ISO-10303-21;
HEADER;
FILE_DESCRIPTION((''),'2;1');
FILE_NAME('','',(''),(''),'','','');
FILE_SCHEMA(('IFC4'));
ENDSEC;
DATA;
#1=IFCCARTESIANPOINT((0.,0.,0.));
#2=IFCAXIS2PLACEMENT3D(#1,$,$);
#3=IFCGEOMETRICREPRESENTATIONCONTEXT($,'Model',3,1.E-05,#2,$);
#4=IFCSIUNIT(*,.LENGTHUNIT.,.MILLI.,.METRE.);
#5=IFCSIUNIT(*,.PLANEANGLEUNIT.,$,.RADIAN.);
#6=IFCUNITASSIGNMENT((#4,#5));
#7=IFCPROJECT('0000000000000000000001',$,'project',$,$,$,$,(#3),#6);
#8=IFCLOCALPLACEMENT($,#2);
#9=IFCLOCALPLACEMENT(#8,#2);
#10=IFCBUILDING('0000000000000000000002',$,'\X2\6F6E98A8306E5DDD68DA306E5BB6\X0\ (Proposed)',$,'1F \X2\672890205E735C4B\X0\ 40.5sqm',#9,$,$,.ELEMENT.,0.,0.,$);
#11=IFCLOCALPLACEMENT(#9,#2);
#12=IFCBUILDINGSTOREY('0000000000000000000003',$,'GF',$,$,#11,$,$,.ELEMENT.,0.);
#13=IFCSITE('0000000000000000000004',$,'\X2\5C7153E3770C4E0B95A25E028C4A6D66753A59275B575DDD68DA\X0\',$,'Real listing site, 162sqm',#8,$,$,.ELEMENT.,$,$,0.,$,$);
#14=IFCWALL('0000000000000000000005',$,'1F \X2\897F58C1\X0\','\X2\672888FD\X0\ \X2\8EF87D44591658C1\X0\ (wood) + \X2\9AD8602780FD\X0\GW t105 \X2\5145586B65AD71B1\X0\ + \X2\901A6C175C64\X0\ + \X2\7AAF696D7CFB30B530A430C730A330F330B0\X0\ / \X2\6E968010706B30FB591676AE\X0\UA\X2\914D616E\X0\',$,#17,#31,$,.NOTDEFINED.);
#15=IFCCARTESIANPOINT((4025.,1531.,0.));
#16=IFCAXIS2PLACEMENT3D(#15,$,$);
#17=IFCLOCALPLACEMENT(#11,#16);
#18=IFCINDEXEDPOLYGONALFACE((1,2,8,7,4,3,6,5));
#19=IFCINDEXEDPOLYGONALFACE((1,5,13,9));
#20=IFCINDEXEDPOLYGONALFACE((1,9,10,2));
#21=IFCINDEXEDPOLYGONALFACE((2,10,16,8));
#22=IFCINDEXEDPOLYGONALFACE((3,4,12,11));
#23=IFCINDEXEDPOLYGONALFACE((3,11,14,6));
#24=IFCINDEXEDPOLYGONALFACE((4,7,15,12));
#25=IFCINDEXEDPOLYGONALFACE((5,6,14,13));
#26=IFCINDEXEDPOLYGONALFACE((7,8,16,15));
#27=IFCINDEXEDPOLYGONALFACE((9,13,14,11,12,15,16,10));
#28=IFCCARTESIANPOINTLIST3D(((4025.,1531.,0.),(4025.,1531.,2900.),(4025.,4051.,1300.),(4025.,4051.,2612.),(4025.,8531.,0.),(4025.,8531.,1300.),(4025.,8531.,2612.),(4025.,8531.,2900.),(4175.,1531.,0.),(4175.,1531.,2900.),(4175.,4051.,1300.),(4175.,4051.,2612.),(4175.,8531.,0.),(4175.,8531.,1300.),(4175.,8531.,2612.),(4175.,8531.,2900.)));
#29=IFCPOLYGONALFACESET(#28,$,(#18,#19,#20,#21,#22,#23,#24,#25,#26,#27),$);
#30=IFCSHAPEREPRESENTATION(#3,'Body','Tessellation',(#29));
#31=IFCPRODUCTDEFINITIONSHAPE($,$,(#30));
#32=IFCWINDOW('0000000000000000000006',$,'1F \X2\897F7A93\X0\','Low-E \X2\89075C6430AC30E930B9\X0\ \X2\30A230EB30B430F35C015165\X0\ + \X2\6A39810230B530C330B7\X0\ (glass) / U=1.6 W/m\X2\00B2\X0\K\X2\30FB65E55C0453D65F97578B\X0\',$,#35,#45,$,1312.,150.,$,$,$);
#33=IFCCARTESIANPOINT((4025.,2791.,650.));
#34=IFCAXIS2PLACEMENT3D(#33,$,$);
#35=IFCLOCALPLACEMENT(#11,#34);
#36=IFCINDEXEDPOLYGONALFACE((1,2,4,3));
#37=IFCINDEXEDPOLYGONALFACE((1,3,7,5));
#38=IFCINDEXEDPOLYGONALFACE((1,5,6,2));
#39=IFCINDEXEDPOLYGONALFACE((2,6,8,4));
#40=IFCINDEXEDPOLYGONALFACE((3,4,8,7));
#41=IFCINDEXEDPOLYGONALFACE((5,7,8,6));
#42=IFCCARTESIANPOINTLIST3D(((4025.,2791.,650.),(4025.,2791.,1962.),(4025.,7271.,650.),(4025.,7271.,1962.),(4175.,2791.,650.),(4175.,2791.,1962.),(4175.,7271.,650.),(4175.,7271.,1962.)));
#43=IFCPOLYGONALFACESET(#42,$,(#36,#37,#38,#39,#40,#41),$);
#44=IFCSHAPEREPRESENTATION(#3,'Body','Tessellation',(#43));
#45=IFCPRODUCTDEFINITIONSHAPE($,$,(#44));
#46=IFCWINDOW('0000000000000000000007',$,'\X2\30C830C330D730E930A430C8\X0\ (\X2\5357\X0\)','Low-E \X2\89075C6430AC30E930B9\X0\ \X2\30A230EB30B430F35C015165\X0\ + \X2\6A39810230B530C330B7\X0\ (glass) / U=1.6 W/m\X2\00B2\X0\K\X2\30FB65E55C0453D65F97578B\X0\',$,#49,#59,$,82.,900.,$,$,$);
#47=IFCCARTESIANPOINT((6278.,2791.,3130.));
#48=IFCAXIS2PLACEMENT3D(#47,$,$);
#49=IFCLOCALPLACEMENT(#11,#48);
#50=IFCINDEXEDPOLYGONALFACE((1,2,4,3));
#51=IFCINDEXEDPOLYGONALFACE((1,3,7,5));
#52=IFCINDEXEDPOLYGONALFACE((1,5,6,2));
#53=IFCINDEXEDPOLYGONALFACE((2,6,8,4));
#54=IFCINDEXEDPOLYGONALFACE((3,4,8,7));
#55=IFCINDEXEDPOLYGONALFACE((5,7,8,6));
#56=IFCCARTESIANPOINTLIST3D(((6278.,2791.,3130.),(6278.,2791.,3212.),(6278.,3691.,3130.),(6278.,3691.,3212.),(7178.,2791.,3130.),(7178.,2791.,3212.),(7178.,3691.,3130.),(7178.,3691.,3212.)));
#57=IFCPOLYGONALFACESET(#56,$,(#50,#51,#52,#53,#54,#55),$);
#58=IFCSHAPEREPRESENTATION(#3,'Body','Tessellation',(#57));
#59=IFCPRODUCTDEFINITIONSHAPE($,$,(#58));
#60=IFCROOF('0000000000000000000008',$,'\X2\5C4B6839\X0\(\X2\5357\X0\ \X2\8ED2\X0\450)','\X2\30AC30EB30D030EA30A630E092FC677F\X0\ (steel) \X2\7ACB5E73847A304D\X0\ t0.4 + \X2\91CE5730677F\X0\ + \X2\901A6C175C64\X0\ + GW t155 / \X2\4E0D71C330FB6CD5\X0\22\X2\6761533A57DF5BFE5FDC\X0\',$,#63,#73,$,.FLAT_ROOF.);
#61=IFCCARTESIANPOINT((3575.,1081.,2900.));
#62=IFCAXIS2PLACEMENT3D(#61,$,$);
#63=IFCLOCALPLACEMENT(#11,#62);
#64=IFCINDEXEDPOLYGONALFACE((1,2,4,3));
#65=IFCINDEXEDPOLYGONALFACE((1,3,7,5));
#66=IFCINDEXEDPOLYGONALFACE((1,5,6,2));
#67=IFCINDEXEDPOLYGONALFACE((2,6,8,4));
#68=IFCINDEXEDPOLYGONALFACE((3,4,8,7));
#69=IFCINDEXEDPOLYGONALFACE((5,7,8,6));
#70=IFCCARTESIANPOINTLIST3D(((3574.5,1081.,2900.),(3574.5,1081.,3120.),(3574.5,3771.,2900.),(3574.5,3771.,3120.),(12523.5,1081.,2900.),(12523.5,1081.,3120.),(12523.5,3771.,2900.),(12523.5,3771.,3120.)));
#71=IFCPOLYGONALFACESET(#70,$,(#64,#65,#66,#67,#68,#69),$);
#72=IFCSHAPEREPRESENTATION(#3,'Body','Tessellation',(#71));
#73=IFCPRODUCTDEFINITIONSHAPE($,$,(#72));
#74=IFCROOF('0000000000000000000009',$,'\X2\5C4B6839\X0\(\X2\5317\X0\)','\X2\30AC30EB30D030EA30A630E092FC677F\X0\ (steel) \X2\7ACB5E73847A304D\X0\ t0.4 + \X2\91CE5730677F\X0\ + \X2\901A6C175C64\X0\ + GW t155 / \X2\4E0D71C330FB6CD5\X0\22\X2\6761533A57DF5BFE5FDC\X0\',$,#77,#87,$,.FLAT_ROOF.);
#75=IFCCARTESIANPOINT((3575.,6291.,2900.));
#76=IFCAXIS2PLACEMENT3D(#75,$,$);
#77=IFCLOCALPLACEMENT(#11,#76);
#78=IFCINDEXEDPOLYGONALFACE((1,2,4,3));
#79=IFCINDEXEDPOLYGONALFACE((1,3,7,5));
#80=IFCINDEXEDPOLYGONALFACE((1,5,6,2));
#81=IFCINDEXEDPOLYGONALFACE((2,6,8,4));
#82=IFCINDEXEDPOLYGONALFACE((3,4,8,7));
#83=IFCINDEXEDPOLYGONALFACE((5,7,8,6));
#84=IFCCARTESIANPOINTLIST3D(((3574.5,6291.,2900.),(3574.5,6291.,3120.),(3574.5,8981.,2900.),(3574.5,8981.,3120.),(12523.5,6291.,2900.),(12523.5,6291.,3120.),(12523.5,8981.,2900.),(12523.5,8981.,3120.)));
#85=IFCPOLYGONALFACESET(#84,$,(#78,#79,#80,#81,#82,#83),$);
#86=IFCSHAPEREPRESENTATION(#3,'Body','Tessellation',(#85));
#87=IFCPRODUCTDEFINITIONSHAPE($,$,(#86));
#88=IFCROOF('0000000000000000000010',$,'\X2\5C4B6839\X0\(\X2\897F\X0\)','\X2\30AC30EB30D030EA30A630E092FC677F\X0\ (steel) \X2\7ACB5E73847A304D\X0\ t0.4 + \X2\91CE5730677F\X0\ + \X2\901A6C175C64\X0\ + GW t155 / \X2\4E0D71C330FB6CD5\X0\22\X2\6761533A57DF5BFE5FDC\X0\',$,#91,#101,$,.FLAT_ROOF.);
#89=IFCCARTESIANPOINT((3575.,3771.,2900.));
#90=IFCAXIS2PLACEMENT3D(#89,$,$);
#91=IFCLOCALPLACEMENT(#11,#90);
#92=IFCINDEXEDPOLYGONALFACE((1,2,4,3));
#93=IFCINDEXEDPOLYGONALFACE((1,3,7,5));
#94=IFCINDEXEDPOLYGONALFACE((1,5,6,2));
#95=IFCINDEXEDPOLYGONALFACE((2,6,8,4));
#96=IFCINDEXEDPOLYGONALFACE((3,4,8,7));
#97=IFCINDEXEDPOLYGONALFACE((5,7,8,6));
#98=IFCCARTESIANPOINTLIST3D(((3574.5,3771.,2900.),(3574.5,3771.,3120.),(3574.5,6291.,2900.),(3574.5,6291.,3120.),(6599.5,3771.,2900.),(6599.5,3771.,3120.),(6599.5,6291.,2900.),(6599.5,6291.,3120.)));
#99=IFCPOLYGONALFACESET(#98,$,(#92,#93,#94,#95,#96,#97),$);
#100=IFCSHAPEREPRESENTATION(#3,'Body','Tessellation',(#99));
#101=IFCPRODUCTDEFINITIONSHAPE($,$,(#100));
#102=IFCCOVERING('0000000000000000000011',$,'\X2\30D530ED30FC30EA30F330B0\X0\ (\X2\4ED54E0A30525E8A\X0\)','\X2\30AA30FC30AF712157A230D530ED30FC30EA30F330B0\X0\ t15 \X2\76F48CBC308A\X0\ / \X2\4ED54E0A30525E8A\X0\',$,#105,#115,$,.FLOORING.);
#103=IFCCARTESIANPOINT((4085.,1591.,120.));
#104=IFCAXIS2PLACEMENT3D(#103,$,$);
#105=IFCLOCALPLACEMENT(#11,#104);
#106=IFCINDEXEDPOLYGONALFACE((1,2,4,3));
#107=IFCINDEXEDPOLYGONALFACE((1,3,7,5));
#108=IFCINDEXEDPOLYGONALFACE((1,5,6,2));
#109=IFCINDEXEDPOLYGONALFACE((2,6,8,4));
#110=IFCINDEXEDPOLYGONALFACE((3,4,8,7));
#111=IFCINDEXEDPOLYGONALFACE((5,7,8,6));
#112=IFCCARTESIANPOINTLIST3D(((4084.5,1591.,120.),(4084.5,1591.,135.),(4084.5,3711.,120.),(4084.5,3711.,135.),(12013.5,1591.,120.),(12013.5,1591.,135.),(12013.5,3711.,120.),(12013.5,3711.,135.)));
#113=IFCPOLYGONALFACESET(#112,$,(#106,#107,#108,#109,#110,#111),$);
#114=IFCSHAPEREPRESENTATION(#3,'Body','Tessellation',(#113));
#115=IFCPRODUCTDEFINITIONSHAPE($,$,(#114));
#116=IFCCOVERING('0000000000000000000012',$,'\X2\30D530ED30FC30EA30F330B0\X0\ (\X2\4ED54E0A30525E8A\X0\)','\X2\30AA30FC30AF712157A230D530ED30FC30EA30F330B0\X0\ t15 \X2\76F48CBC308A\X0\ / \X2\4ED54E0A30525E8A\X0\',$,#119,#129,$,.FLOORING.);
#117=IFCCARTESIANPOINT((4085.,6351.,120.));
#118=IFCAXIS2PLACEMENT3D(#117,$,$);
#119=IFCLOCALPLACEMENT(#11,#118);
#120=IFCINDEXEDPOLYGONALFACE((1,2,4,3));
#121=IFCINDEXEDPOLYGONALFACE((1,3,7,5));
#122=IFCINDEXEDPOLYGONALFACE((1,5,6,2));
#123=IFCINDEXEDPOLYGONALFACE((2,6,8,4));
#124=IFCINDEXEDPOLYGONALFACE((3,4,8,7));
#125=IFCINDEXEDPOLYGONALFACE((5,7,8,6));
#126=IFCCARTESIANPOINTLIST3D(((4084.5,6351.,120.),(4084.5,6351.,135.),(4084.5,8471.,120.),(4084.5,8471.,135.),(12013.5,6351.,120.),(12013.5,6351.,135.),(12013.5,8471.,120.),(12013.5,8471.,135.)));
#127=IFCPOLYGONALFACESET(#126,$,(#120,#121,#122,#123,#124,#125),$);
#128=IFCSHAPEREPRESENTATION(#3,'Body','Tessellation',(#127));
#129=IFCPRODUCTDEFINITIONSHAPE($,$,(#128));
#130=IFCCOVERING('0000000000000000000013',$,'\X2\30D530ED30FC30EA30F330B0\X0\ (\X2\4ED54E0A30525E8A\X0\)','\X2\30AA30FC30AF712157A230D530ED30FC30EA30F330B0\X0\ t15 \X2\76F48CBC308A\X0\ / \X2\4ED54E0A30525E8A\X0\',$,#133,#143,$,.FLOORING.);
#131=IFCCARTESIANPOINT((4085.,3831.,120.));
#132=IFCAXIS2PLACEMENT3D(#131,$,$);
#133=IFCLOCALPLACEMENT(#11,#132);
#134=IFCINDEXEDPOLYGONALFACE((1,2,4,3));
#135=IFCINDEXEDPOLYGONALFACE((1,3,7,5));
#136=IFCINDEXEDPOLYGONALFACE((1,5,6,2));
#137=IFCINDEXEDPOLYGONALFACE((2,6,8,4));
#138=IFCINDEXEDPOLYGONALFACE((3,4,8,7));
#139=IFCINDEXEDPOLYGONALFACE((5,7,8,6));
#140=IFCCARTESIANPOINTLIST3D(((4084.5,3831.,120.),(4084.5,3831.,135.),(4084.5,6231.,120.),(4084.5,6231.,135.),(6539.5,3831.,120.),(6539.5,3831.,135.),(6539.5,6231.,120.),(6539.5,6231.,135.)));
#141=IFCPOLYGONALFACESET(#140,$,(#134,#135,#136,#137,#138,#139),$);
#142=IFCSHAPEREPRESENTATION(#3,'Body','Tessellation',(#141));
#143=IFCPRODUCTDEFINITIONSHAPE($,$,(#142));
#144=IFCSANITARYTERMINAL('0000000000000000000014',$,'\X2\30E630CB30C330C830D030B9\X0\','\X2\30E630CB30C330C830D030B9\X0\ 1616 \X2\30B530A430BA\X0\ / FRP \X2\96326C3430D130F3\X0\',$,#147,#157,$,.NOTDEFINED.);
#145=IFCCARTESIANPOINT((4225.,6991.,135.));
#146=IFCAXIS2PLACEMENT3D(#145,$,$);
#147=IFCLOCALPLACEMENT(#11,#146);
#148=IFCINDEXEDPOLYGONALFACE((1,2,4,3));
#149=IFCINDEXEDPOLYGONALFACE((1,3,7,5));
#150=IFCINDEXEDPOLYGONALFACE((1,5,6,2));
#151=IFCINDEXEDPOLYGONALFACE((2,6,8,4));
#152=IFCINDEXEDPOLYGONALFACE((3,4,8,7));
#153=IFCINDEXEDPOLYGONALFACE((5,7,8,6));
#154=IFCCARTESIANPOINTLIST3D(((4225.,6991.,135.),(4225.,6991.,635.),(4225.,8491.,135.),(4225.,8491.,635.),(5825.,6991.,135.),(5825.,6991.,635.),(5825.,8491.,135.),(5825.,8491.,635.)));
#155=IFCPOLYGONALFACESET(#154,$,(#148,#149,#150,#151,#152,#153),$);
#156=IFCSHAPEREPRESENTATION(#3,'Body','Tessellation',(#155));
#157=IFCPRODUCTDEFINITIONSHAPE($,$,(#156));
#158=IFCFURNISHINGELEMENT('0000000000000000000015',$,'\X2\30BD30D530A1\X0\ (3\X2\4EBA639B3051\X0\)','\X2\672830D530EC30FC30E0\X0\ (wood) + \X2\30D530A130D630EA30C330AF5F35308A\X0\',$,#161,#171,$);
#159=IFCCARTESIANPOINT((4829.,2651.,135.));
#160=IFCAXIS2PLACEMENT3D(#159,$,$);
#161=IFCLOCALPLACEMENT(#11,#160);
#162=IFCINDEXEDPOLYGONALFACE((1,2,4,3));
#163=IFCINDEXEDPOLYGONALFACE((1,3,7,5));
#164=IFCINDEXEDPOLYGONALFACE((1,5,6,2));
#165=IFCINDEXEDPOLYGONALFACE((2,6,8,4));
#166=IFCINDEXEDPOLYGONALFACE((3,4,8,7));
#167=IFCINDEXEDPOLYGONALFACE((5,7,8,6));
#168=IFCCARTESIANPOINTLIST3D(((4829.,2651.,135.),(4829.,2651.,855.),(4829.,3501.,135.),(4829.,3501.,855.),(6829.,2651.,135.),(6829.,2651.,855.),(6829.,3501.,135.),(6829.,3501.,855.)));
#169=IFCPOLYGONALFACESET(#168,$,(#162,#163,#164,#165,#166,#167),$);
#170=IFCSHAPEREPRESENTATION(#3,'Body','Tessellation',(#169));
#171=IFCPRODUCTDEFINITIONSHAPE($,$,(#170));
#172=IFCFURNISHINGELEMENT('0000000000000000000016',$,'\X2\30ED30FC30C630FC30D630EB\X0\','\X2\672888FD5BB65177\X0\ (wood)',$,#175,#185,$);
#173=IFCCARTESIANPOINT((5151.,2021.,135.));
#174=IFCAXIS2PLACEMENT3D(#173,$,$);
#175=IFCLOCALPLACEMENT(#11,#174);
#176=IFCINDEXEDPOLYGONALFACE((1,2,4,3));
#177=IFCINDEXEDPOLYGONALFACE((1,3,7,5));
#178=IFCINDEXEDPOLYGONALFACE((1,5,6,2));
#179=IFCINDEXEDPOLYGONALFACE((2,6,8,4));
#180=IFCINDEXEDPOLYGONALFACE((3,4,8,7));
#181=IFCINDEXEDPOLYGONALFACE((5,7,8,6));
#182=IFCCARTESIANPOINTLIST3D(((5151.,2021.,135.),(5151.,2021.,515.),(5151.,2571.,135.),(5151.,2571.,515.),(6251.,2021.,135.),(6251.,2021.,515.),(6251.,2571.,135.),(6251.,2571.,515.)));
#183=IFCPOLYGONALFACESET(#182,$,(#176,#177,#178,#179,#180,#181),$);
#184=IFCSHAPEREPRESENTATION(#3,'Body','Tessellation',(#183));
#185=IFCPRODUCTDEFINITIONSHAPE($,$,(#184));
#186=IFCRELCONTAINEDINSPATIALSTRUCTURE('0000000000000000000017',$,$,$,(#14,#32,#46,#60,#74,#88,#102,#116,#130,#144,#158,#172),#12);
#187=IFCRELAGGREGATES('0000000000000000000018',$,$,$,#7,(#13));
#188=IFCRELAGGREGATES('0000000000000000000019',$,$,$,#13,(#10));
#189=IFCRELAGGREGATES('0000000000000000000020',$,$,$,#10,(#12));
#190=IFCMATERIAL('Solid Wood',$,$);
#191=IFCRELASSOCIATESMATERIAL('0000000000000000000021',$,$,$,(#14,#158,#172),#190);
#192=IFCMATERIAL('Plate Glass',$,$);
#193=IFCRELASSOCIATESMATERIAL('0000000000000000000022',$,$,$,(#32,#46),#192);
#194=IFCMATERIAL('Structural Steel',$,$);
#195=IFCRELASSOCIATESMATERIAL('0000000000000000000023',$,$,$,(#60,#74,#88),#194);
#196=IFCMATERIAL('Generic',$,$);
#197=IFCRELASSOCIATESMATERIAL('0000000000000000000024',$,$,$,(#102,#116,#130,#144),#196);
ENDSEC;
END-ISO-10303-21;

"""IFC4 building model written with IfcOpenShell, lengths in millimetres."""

from ifc_helpers import new_model, si_unit, frame, frame_2d, origin, place, context, project, spatial, rectangle, extrude, material, element, fill, save


model = new_model("IFC4")

# Units and contexts
model_context = context("Model", 3, precision=1e-05, world=origin())
ifc_project = project(units=[si_unit("LENGTHUNIT", "METRE", prefix="MILLI"), si_unit("PLANEANGLEUNIT", "RADIAN")], contexts=[model_context])

# Site, building, storey
site_placement = place(None, origin())
site = spatial("IfcSite", under=ifc_project, at=site_placement, Name="山口県下関市豊浦町大字川棚", ObjectType="Real listing site, 162sqm", CompositionType="ELEMENT", RefElevation=0.0)
building_placement = place(site_placement, origin())
building = spatial("IfcBuilding", under=site, at=building_placement, Name="潮風の川棚の家 (Proposed)", ObjectType="1F 木造平屋 40.5sqm", CompositionType="ELEMENT", ElevationOfRefHeight=0.0, ElevationOfTerrain=0.0)
storey_placement = place(building_placement, origin())
storey = spatial("IfcBuildingStorey", under=building, at=storey_placement, Name="GF", CompositionType="ELEMENT", Elevation=0.0)

# Shared definitions
ifc_material_1 = material(Name="Solid Wood")

# Shared definitions
ifc_material_2 = material(Name="Plate Glass")

# Wall, opening, window
wall_1_placement = place(storey_placement, frame((4025.0, 1531.0, 0.0)))
wall_1 = element("IfcWall", 1, at=wall_1_placement, inside=storey, material=ifc_material_1, Name="1F 西壁", Description="木製 軸組外壁 (wood) + 高性能GW t105 充填断熱 + 通気層 + 窯業系サイディング / 準耐火・外皮UA配慮", PredefinedType="NOTDEFINED", context=model_context, shape_type="SweptSolid", body=[
    extrude(rectangle(XDim=150.0, YDim=7000.0, at=frame_2d((75.0, 3500.0))), frame((4025.0, 1531.0, 0.0)), (0.0, 0.0, 1.0), 2900.0),
])
opening_1_placement = place(storey_placement, frame((4025.0, 2791.0, 650.0)))
opening_1 = element("IfcOpeningElement", 2, at=opening_1_placement, cuts=wall_1, PredefinedType="NOTDEFINED", context=model_context, shape_type="SweptSolid", body=[
    extrude(rectangle(XDim=150.0, YDim=4480.0, at=frame_2d((75.0, 2240.0))), frame((4025.0, 2791.0, 650.0)), (0.0, 0.0, 1.0), 1312.0),
])
window_1_placement = place(storey_placement, frame((4025.0, 2791.0, 650.0)))
window_1 = element("IfcWindow", 3, at=window_1_placement, inside=storey, material=ifc_material_2, Name="1F 西窓", Description="Low-E 複層ガラス アルゴン封入 + 樹脂サッシ (glass) / U=1.6 W/m²K・日射取得型", OverallHeight=1312.0, OverallWidth=150.0, context=model_context, shape_type="SweptSolid", body=[
    extrude(rectangle(XDim=150.0, YDim=4480.0, at=frame_2d((75.0, 2240.0))), frame((4025.0, 2791.0, 650.0)), (0.0, 0.0, 1.0), 1312.0),
])
fill(opening_1, window_1)

# Window
window_2_placement = place(storey_placement, frame((6278.0, 2791.0, 3130.0)))
element("IfcWindow", 4, at=window_2_placement, inside=storey, material=ifc_material_2, Name="トップライト (南)", Description="Low-E 複層ガラス アルゴン封入 + 樹脂サッシ (glass) / U=1.6 W/m²K・日射取得型", OverallHeight=82.0, OverallWidth=900.0, context=model_context, shape_type="SweptSolid", body=[
    extrude(rectangle(XDim=900.0, YDim=900.0, at=frame_2d((450.0, 450.0))), frame((6278.0, 2791.0, 3130.0)), (0.0, 0.0, 1.0), 82.0),
])

# Roofs
ifc_material_3 = material(Name="Structural Steel")
roof_1_placement = place(storey_placement, frame((3575.0, 1081.0, 2900.0)))
element("IfcRoof", 5, at=roof_1_placement, inside=storey, material=ifc_material_3, Name="屋根(南 軒450)", Description="ガルバリウム鋼板 (steel) 立平葺き t0.4 + 野地板 + 通気層 + GW t155 / 不燃・法22条区域対応", PredefinedType="FLAT_ROOF", context=model_context, shape_type="SweptSolid", body=[
    extrude(rectangle(XDim=8949.0, YDim=2690.0, at=frame_2d((4474.0, 1345.0))), frame((3575.0, 1081.0, 2900.0)), (0.0, 0.0, 1.0), 220.0),
])
roof_2_placement = place(storey_placement, frame((3575.0, 6291.0, 2900.0)))
element("IfcRoof", 6, at=roof_2_placement, inside=storey, material=ifc_material_3, Name="屋根(北)", Description="ガルバリウム鋼板 (steel) 立平葺き t0.4 + 野地板 + 通気層 + GW t155 / 不燃・法22条区域対応", PredefinedType="FLAT_ROOF", context=model_context, shape_type="SweptSolid", body=[
    extrude(rectangle(XDim=8949.0, YDim=2690.0, at=frame_2d((4474.0, 1345.0))), frame((3575.0, 6291.0, 2900.0)), (0.0, 0.0, 1.0), 220.0),
])
roof_3_placement = place(storey_placement, frame((3575.0, 3771.0, 2900.0)))
element("IfcRoof", 7, at=roof_3_placement, inside=storey, material=ifc_material_3, Name="屋根(西)", Description="ガルバリウム鋼板 (steel) 立平葺き t0.4 + 野地板 + 通気層 + GW t155 / 不燃・法22条区域対応", PredefinedType="FLAT_ROOF", context=model_context, shape_type="SweptSolid", body=[
    extrude(rectangle(XDim=3025.0, YDim=2520.0, at=frame_2d((1512.0, 1260.0))), frame((3575.0, 3771.0, 2900.0)), (0.0, 0.0, 1.0), 220.0),
])

# Coverings
ifc_material_4 = material(Name="Generic")
covering_1_placement = place(storey_placement, frame((4085.0, 1591.0, 120.0)))
element("IfcCovering", 8, at=covering_1_placement, inside=storey, material=ifc_material_4, Name="フローリング (仕上げ床)", Description="オーク無垢フローリング t15 直貼り / 仕上げ床", PredefinedType="FLOORING", context=model_context, shape_type="SweptSolid", body=[
    extrude(rectangle(XDim=7929.0, YDim=2120.0, at=frame_2d((3964.0, 1060.0))), frame((4085.0, 1591.0, 120.0)), (0.0, 0.0, 1.0), 15.0),
])
covering_2_placement = place(storey_placement, frame((4085.0, 6351.0, 120.0)))
element("IfcCovering", 9, at=covering_2_placement, inside=storey, material=ifc_material_4, Name="フローリング (仕上げ床)", Description="オーク無垢フローリング t15 直貼り / 仕上げ床", PredefinedType="FLOORING", context=model_context, shape_type="SweptSolid", body=[
    extrude(rectangle(XDim=7929.0, YDim=2120.0, at=frame_2d((3964.0, 1060.0))), frame((4085.0, 6351.0, 120.0)), (0.0, 0.0, 1.0), 15.0),
])
covering_3_placement = place(storey_placement, frame((4085.0, 3831.0, 120.0)))
element("IfcCovering", 10, at=covering_3_placement, inside=storey, material=ifc_material_4, Name="フローリング (仕上げ床)", Description="オーク無垢フローリング t15 直貼り / 仕上げ床", PredefinedType="FLOORING", context=model_context, shape_type="SweptSolid", body=[
    extrude(rectangle(XDim=2455.0, YDim=2400.0, at=frame_2d((1227.0, 1200.0))), frame((4085.0, 3831.0, 120.0)), (0.0, 0.0, 1.0), 15.0),
])

# Sanitary terminal
sanitary_terminal_placement = place(storey_placement, frame((4225.0, 6991.0, 135.0)))
element("IfcSanitaryTerminal", 11, at=sanitary_terminal_placement, inside=storey, material=ifc_material_4, Name="ユニットバス", Description="ユニットバス 1616 サイズ / FRP 防水パン", PredefinedType="NOTDEFINED", context=model_context, shape_type="SweptSolid", body=[
    extrude(rectangle(XDim=1600.0, YDim=1500.0, at=frame_2d((800.0, 750.0))), frame((4225.0, 6991.0, 135.0)), (0.0, 0.0, 1.0), 500.0),
])

# Furnishing elements
furnishing_1_placement = place(storey_placement, frame((4829.0, 2651.0, 135.0)))
element("IfcFurnishingElement", 12, at=furnishing_1_placement, inside=storey, material=ifc_material_1, Name="ソファ (3人掛け)", Description="木フレーム (wood) + ファブリック張り", context=model_context, shape_type="SweptSolid", body=[
    extrude(rectangle(XDim=2000.0, YDim=850.0, at=frame_2d((1000.0, 425.0))), frame((4829.0, 2651.0, 135.0)), (0.0, 0.0, 1.0), 720.0),
])
furnishing_2_placement = place(storey_placement, frame((5151.0, 2021.0, 135.0)))
element("IfcFurnishingElement", 13, at=furnishing_2_placement, inside=storey, material=ifc_material_1, Name="ローテーブル", Description="木製家具 (wood)", context=model_context, shape_type="SweptSolid", body=[
    extrude(rectangle(XDim=1100.0, YDim=550.0, at=frame_2d((550.0, 275.0))), frame((5151.0, 2021.0, 135.0)), (0.0, 0.0, 1.0), 380.0),
])

save(model, "model.ifc")
